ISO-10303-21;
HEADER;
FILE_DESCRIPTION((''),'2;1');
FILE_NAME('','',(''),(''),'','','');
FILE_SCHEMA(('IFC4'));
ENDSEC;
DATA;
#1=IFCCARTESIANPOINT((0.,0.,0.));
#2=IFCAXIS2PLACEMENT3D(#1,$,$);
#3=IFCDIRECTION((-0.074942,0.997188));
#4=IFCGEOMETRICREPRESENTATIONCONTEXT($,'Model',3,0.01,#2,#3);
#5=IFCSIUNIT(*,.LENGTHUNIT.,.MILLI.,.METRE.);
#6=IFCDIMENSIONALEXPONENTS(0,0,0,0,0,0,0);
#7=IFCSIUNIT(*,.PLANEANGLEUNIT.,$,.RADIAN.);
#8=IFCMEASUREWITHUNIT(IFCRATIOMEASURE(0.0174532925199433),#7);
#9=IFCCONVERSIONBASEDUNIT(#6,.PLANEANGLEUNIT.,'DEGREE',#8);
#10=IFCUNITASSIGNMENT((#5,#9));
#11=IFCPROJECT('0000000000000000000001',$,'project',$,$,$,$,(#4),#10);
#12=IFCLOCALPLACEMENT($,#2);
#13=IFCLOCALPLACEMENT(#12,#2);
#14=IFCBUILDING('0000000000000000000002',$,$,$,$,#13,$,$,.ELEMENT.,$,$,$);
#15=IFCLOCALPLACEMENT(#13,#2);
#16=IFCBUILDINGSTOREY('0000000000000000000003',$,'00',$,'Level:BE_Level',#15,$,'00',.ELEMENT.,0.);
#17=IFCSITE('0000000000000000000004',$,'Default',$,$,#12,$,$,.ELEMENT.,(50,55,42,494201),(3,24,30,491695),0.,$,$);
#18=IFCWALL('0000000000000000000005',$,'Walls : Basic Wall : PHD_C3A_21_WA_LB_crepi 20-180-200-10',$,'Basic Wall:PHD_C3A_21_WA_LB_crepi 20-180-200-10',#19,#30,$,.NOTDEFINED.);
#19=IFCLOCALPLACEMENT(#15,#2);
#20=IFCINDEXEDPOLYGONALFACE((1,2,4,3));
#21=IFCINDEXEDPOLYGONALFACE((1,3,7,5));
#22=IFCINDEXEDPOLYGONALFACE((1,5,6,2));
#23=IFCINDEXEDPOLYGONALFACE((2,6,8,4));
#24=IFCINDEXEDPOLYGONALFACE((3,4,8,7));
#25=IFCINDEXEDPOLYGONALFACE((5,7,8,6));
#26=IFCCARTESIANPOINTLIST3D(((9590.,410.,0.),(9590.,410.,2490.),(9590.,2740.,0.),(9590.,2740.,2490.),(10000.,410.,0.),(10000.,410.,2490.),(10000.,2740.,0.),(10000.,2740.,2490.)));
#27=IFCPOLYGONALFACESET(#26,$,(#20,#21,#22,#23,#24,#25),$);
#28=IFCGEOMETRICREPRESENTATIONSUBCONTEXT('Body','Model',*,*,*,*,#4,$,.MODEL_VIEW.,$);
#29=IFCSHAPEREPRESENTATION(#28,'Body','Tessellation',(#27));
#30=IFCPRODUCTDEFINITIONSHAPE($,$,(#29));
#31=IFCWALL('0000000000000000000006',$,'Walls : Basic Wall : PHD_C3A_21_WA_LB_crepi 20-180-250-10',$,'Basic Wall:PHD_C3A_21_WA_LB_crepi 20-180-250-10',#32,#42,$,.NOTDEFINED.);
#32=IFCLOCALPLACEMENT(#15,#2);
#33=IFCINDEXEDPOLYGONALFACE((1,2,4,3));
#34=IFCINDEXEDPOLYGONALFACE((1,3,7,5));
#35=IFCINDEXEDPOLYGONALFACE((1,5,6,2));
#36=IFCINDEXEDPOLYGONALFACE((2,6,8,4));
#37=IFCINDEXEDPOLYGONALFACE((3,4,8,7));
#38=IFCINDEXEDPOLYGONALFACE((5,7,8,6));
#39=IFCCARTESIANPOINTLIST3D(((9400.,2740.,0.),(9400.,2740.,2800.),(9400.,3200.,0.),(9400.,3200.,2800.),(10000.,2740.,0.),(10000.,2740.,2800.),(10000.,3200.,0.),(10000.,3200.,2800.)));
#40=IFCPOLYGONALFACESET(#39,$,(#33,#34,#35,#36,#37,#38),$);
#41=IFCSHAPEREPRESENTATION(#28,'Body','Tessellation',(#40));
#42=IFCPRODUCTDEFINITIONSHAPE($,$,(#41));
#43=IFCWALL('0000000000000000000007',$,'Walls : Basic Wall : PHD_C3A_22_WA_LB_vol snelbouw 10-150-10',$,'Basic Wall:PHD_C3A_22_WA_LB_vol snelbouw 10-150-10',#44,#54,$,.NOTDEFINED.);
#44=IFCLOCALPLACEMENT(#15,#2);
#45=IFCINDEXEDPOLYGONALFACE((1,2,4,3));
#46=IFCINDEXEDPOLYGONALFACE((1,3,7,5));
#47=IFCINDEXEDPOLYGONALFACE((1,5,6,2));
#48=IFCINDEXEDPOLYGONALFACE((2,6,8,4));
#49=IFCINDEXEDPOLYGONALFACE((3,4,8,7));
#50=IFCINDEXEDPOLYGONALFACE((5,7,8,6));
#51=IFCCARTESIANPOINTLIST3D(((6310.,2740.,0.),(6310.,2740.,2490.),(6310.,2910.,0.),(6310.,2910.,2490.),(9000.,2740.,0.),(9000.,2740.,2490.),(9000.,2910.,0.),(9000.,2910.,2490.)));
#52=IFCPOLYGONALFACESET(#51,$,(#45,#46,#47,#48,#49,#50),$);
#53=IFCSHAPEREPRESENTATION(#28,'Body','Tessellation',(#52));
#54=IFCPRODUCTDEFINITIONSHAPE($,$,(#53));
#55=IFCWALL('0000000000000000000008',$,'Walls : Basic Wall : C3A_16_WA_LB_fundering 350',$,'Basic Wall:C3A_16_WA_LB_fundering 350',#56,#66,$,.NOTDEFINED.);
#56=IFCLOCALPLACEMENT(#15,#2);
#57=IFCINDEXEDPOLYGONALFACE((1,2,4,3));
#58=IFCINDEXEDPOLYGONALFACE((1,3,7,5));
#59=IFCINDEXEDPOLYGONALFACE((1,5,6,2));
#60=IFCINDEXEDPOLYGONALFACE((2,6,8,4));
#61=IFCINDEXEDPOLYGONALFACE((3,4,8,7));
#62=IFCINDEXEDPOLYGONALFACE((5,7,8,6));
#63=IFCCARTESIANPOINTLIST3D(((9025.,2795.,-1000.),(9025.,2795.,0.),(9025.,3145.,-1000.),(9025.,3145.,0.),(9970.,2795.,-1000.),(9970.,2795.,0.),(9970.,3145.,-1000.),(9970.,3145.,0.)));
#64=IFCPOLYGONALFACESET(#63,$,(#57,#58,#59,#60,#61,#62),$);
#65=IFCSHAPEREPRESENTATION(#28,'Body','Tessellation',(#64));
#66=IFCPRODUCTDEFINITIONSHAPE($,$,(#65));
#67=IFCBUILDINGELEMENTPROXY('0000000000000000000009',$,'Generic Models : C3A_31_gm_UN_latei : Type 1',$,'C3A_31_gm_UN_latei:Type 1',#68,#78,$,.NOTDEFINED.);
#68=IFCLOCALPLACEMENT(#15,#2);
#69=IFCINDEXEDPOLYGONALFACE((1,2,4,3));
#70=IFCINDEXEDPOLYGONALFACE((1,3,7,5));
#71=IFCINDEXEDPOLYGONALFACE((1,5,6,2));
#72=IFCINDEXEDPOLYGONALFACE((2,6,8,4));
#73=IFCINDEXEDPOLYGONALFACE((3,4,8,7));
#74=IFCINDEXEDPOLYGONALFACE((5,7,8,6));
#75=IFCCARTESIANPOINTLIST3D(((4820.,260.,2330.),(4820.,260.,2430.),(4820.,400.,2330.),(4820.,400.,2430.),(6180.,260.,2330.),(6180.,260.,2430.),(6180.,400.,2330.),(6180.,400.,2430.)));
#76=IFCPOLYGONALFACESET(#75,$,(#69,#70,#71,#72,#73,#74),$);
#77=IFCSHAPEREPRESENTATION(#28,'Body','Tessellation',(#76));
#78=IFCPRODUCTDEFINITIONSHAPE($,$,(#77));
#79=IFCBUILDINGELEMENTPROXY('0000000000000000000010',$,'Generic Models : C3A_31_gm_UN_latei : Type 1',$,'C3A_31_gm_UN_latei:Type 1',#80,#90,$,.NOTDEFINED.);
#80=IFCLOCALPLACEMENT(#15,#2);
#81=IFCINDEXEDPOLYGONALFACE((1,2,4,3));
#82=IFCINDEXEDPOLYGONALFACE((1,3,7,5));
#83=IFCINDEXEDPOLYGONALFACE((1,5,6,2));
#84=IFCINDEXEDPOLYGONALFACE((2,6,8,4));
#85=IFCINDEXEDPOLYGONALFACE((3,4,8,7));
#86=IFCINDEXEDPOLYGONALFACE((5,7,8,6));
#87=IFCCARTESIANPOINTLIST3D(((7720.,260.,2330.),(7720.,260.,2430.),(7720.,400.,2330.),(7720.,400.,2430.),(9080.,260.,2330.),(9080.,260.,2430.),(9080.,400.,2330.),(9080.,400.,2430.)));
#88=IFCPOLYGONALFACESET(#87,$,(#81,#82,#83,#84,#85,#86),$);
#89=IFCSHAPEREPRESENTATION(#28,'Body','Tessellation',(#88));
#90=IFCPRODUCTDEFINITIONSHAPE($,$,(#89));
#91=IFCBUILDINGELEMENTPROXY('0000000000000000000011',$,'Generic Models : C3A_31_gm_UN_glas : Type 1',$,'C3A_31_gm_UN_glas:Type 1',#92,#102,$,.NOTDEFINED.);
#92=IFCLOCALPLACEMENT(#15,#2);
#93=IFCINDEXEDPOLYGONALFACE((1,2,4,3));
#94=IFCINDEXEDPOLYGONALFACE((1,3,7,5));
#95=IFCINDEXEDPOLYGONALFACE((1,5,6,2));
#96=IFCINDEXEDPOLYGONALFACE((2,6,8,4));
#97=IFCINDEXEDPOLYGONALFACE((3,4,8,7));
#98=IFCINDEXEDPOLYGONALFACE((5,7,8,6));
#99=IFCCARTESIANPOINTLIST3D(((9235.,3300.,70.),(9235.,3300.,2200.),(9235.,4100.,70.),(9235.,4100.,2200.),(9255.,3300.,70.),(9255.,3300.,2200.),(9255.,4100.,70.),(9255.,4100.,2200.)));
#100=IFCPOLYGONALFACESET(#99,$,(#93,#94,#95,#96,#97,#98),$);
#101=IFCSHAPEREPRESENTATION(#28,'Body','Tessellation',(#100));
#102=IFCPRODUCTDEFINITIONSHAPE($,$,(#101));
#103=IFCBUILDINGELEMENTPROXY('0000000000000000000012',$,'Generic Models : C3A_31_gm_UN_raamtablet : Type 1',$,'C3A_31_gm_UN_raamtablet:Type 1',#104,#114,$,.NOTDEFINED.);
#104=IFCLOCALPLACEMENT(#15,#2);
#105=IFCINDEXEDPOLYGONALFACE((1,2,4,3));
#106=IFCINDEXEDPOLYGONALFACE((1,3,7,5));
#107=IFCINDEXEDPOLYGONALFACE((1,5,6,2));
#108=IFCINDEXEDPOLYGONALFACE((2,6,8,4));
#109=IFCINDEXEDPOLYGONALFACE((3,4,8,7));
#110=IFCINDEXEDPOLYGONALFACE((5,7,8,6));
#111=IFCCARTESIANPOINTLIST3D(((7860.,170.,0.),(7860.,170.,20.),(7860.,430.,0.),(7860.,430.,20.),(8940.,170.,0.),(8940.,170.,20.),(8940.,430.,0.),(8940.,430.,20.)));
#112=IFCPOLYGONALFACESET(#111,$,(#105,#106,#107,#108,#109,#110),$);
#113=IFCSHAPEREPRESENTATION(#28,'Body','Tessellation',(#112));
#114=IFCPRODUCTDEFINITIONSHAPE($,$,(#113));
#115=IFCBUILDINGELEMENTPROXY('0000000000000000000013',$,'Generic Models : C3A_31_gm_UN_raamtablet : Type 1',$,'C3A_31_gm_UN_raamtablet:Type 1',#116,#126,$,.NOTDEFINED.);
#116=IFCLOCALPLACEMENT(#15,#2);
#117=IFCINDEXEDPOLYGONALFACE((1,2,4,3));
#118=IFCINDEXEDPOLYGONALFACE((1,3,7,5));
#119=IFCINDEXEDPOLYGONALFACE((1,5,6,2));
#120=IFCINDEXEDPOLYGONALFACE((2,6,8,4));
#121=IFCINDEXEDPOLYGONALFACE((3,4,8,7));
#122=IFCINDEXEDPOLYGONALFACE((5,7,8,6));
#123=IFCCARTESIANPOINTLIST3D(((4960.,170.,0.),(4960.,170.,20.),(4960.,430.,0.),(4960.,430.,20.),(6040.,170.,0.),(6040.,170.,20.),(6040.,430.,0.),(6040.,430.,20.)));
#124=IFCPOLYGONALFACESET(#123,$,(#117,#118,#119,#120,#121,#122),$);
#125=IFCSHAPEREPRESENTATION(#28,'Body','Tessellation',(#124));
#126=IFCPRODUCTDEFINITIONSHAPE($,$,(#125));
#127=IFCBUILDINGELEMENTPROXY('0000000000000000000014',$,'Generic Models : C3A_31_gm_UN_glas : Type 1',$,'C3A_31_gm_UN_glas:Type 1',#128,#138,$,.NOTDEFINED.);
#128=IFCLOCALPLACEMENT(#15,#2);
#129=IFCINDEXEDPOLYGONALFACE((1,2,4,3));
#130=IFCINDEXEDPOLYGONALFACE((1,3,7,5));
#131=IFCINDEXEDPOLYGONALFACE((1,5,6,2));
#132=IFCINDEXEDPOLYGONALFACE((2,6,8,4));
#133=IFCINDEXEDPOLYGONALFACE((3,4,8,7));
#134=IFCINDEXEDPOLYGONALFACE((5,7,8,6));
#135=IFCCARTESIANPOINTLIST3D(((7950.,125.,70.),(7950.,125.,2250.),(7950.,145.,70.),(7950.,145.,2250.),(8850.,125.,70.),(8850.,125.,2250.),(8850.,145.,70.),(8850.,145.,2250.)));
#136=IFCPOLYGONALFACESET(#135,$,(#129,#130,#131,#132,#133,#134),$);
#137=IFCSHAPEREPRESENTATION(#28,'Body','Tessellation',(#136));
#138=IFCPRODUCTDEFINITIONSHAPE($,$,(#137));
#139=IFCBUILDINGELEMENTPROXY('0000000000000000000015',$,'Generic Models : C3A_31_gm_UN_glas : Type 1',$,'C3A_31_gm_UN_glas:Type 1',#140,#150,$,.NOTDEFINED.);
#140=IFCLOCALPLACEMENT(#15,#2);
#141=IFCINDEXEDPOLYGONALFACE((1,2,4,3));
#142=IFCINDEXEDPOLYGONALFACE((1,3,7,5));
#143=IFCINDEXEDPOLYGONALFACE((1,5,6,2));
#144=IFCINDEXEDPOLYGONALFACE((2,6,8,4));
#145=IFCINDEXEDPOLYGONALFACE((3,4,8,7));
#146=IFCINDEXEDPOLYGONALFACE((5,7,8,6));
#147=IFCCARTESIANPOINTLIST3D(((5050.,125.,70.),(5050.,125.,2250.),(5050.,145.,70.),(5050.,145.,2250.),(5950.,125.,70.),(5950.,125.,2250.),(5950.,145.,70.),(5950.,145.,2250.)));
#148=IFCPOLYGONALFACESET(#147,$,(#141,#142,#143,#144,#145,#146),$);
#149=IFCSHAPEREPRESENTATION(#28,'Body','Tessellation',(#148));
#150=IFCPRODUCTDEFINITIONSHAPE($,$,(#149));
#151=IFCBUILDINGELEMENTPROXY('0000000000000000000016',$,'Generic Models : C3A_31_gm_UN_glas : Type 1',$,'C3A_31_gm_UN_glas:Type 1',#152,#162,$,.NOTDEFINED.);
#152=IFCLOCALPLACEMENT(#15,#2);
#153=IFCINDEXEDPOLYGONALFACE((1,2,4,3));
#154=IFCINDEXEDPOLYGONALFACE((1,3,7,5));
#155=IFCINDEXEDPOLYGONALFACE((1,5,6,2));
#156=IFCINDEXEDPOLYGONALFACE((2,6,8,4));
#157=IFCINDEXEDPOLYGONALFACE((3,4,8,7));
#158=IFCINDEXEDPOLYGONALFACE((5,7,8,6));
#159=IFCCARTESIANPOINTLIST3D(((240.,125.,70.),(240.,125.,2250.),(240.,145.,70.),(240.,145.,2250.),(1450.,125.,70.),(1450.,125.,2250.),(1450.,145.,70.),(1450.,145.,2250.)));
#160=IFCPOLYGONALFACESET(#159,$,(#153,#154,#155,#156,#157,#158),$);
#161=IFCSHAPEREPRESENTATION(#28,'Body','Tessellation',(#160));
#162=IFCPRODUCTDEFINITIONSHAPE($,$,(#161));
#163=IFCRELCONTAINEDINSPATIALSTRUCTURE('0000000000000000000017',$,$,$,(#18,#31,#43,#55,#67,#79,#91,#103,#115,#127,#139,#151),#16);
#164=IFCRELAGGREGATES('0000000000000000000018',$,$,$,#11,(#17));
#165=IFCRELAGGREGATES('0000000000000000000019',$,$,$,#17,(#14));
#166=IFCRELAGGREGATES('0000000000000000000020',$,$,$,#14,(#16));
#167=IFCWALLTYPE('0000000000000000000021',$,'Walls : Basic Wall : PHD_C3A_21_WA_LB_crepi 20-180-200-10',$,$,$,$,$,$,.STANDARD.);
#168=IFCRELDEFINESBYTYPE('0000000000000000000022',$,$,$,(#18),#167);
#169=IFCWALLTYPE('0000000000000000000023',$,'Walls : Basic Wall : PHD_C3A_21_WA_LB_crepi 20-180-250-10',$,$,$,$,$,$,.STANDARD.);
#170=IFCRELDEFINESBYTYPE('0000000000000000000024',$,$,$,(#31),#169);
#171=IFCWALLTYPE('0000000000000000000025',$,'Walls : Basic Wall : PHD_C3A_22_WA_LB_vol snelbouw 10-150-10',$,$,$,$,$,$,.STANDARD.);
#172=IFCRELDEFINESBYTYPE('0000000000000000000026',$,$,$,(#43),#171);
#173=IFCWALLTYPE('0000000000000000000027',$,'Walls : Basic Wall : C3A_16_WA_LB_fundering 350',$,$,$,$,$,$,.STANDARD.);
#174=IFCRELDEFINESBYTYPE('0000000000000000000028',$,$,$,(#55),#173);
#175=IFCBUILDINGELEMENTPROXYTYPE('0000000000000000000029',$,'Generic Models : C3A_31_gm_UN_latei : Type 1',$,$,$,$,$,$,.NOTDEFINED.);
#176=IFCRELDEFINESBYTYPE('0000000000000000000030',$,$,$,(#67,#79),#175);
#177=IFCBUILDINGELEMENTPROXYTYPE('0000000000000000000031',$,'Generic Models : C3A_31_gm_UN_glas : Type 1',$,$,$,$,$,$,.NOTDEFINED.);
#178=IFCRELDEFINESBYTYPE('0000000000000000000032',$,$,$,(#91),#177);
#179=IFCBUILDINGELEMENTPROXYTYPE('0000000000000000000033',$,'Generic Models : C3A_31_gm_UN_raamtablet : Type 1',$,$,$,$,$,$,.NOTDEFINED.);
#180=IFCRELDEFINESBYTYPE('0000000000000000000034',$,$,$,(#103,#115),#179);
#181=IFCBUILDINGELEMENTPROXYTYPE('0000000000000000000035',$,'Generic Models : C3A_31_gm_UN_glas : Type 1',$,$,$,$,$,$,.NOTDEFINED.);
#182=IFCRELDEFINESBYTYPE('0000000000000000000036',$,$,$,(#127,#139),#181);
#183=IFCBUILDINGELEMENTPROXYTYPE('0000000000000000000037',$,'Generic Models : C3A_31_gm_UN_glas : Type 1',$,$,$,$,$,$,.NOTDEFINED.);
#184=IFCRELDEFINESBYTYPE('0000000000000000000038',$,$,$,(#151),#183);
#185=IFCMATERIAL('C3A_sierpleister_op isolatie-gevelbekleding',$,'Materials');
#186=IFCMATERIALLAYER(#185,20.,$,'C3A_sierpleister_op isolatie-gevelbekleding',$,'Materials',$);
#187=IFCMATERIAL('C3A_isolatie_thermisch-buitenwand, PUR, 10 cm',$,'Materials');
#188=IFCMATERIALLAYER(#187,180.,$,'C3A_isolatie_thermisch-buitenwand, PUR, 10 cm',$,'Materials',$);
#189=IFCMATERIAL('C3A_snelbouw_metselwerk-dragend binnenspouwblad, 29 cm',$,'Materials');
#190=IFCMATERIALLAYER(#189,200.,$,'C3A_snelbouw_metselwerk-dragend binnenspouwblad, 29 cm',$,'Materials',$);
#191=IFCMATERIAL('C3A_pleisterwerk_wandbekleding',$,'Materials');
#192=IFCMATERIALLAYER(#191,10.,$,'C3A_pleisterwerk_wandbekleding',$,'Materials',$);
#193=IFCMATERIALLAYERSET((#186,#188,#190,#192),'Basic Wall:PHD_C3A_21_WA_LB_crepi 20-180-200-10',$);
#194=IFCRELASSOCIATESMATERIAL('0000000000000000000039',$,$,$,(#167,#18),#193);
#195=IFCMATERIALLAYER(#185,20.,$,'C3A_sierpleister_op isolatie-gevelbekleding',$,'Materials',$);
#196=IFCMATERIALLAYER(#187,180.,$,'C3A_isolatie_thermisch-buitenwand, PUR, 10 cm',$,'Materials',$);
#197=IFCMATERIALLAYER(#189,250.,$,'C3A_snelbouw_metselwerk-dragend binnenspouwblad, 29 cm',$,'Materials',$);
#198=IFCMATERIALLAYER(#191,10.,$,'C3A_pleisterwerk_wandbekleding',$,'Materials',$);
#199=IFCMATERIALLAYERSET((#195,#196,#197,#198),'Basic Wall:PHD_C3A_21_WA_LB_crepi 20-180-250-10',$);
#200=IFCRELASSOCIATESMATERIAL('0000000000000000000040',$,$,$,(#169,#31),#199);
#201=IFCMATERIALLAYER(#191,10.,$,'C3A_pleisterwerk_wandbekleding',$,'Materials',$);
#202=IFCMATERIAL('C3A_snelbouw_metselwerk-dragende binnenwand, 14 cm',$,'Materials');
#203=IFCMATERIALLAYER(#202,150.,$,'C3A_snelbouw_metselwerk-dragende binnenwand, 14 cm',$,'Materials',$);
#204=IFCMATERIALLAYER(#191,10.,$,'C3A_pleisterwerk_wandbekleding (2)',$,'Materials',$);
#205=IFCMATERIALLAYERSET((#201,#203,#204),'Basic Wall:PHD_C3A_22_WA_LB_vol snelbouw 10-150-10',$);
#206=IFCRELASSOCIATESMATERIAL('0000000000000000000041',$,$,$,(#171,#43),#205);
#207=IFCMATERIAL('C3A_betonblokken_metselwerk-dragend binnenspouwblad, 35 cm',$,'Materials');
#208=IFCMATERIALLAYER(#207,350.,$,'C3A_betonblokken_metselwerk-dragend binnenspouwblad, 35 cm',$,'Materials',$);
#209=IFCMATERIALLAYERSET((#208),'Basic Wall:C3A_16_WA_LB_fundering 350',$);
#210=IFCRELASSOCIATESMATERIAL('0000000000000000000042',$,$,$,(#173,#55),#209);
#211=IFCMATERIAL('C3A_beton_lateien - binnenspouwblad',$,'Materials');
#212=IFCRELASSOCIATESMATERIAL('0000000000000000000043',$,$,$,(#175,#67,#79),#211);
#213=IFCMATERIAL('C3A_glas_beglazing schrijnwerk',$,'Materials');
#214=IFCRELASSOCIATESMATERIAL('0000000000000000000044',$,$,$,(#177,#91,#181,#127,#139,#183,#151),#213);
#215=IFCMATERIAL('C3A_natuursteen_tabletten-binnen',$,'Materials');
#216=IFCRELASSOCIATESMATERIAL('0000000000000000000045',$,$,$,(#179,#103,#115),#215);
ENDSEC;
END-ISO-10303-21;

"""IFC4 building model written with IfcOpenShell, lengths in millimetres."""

from ifc_helpers import new_model, entity, si_unit, converted_unit, direction, frame, frame_2d, origin, origin_2d_with_axis, place, context, subcontext, project, spatial, polyline, rectangle, extrude, clip, bounded_halfspace, source, transform, mapped, material, layer, layer_set, layer_usage, type_object, type_shapes, element, save


model = new_model("IFC4")

# Units and contexts
model_context = context("Model", 3, precision=0.01, world=origin(), true_north=direction((-0.074942, 0.997188)))
body_context = subcontext(model_context, "Body", "Model", "MODEL_VIEW")
ifc_project = project(units=[si_unit("LENGTHUNIT", "METRE", prefix="MILLI"), converted_unit("PLANEANGLEUNIT", "DEGREE", entity("IfcRatioMeasure", 0.0174532925199433), si_unit("PLANEANGLEUNIT", "RADIAN"), dimensions=[0, 0, 0, 0, 0, 0, 0])], contexts=[model_context])

# Site, building, storey
site_placement = place(None, origin())
site = spatial("IfcSite", under=ifc_project, at=site_placement, Name="Default", CompositionType="ELEMENT", RefLatitude=(50, 55, 42, 494201), RefLongitude=(3, 24, 30, 491695), RefElevation=0.0)
building_placement = place(site_placement, origin())
building = spatial("IfcBuilding", under=site, at=building_placement, CompositionType="ELEMENT")
storey_placement = place(building_placement, frame((0.0, 0.0, 0.0)))
storey = spatial("IfcBuildingStorey", under=building, at=storey_placement, Name="00", ObjectType="Level:BE_Level", LongName="00", CompositionType="ELEMENT", Elevation=0.0)

# Walls
ifc_material_1 = material(Name="C3A_sierpleister_op isolatie-gevelbekleding", Category="Materials")
ifc_layer_1 = layer(ifc_material_1, 20.0, Name="C3A_sierpleister_op isolatie-gevelbekleding", Category="Materials")
ifc_material_2 = material(Name="C3A_isolatie_thermisch-buitenwand, PUR, 10 cm", Category="Materials")
ifc_layer_2 = layer(ifc_material_2, 180.0, Name="C3A_isolatie_thermisch-buitenwand, PUR, 10 cm", Category="Materials")
ifc_material_3 = material(Name="C3A_snelbouw_metselwerk-dragend binnenspouwblad, 29 cm", Category="Materials")
ifc_layer_3 = layer(ifc_material_3, 200.0, Name="C3A_snelbouw_metselwerk-dragend binnenspouwblad, 29 cm", Category="Materials")
ifc_material_4 = material(Name="C3A_pleisterwerk_wandbekleding", Category="Materials")
ifc_layer_4 = layer(ifc_material_4, 10.0, Name="C3A_pleisterwerk_wandbekleding", Category="Materials")
ifc_layer_set_1 = layer_set([ifc_layer_1, ifc_layer_2, ifc_layer_3, ifc_layer_4], Name="Basic Wall:PHD_C3A_21_WA_LB_crepi 20-180-200-10")
ifc_layer_usage_1 = layer_usage(ifc_layer_set_1, "AXIS2", "POSITIVE", -205.0)
wall_type_1 = type_object("IfcWallType", Name="Walls : Basic Wall : PHD_C3A_21_WA_LB_crepi 20-180-200-10", PredefinedType="STANDARD", material=ifc_layer_set_1)
wall_1_placement = place(storey_placement, frame((9795.0, 410.0, 0.0), z_axis=(0.0, 0.0, 1.0), x_axis=(0.0, 1.0, 0.0)))
element("IfcWall", 1, at=wall_1_placement, inside=storey, type_object=wall_type_1, material=ifc_layer_usage_1, Name="Walls : Basic Wall : PHD_C3A_21_WA_LB_crepi 20-180-200-10", ObjectType="Basic Wall:PHD_C3A_21_WA_LB_crepi 20-180-200-10", PredefinedType="NOTDEFINED", context=body_context, shape_type="Clipping", body=[
    clip(extrude(rectangle(XDim=2330.0, YDim=410.0, at=frame_2d((1165.0, 0.0), x_axis=(-1.0, 0.0))), origin(), (0.0, 0.0, 1.0), 2490.0), bounded_halfspace(frame((2330.0, 205.0, 2490.0), z_axis=(0.0, 0.0, -1.0), x_axis=(-1.0, 0.0, 0.0)), True, frame((2330.0, 205.0, 2490.0), z_axis=(0.0, 0.0, -1.0), x_axis=(-1.0, 0.0, 0.0)), polyline([(0.0, 0.0), (0.0, -210.0), (0.0, -410.0), (2330.0, -410.0), (2330.0, -210.0), (2330.0, 0.0), (0.0, 0.0)]))),
])
ifc_layer_5 = layer(ifc_material_1, 20.0, Name="C3A_sierpleister_op isolatie-gevelbekleding", Category="Materials")
ifc_layer_6 = layer(ifc_material_2, 180.0, Name="C3A_isolatie_thermisch-buitenwand, PUR, 10 cm", Category="Materials")
ifc_layer_7 = layer(ifc_material_3, 250.0, Name="C3A_snelbouw_metselwerk-dragend binnenspouwblad, 29 cm", Category="Materials")
ifc_layer_8 = layer(ifc_material_4, 10.0, Name="C3A_pleisterwerk_wandbekleding", Category="Materials")
ifc_layer_set_2 = layer_set([ifc_layer_5, ifc_layer_6, ifc_layer_7, ifc_layer_8], Name="Basic Wall:PHD_C3A_21_WA_LB_crepi 20-180-250-10")
ifc_layer_usage_2 = layer_usage(ifc_layer_set_2, "AXIS2", "POSITIVE", -230.0)
wall_type_2 = type_object("IfcWallType", Name="Walls : Basic Wall : PHD_C3A_21_WA_LB_crepi 20-180-250-10", PredefinedType="STANDARD", material=ifc_layer_set_2)
wall_2_placement = place(storey_placement, frame((10000.0, 2970.0, 0.0), z_axis=(0.0, 0.0, 1.0), x_axis=(-1.0, 0.0, 0.0)))
element("IfcWall", 2, at=wall_2_placement, inside=storey, type_object=wall_type_2, material=ifc_layer_usage_2, Name="Walls : Basic Wall : PHD_C3A_21_WA_LB_crepi 20-180-250-10", ObjectType="Basic Wall:PHD_C3A_21_WA_LB_crepi 20-180-250-10", PredefinedType="NOTDEFINED", context=body_context, shape_type="SweptSolid", body=[
    extrude(rectangle(XDim=600.0, YDim=460.0, at=frame_2d((300.0, 0.0), x_axis=(-1.0, 0.0))), origin(), (0.0, 0.0, 1.0), 2800.0),
])
ifc_layer_9 = layer(ifc_material_4, 10.0, Name="C3A_pleisterwerk_wandbekleding", Category="Materials")
ifc_material_5 = material(Name="C3A_snelbouw_metselwerk-dragende binnenwand, 14 cm", Category="Materials")
ifc_layer_10 = layer(ifc_material_5, 150.0, Name="C3A_snelbouw_metselwerk-dragende binnenwand, 14 cm", Category="Materials")
ifc_layer_11 = layer(ifc_material_4, 10.0, Name="C3A_pleisterwerk_wandbekleding (2)", Category="Materials")
ifc_layer_set_3 = layer_set([ifc_layer_9, ifc_layer_10, ifc_layer_11], Name="Basic Wall:PHD_C3A_22_WA_LB_vol snelbouw 10-150-10")
ifc_layer_usage_3 = layer_usage(ifc_layer_set_3, "AXIS2", "NEGATIVE", 85.0)
wall_type_3 = type_object("IfcWallType", Name="Walls : Basic Wall : PHD_C3A_22_WA_LB_vol snelbouw 10-150-10", PredefinedType="STANDARD", material=ifc_layer_set_3)
wall_3_placement = place(storey_placement, frame((6310.0, 2825.0, 0.0)))
element("IfcWall", 3, at=wall_3_placement, inside=storey, type_object=wall_type_3, material=ifc_layer_usage_3, Name="Walls : Basic Wall : PHD_C3A_22_WA_LB_vol snelbouw 10-150-10", ObjectType="Basic Wall:PHD_C3A_22_WA_LB_vol snelbouw 10-150-10", PredefinedType="NOTDEFINED", context=body_context, shape_type="Clipping", body=[
    clip(extrude(rectangle(XDim=2690.0, YDim=170.0, at=frame_2d((1345.0, 0.0), x_axis=(-1.0, 0.0))), origin(), (0.0, 0.0, 1.0), 2490.0), bounded_halfspace(frame((0.0, -85.0, 2490.0), z_axis=(0.0, 0.0, -1.0), x_axis=(0.0, -1.0, 0.0)), True, frame((0.0, -85.0, 2490.0), z_axis=(0.0, 0.0, -1.0), x_axis=(0.0, -1.0, 0.0)), polyline([(0.0, 0.0), (-170.0, 0.0), (-170.0, -2690.0), (0.0, -2690.0), (0.0, 0.0)]))),
])

# Wall
ifc_material_6 = material(Name="C3A_betonblokken_metselwerk-dragend binnenspouwblad, 35 cm", Category="Materials")
ifc_layer_12 = layer(ifc_material_6, 350.0, Name="C3A_betonblokken_metselwerk-dragend binnenspouwblad, 35 cm", Category="Materials")
ifc_layer_set_4 = layer_set([ifc_layer_12], Name="Basic Wall:C3A_16_WA_LB_fundering 350")
ifc_layer_usage_4 = layer_usage(ifc_layer_set_4, "AXIS2", "NEGATIVE", 175.0)
wall_type_4 = type_object("IfcWallType", Name="Walls : Basic Wall : C3A_16_WA_LB_fundering 350", PredefinedType="STANDARD", material=ifc_layer_set_4)
wall_4_placement = place(storey_placement, frame((9025.0, 2970.0, -1000.0)))
element("IfcWall", 4, at=wall_4_placement, inside=storey, type_object=wall_type_4, material=ifc_layer_usage_4, Name="Walls : Basic Wall : C3A_16_WA_LB_fundering 350", ObjectType="Basic Wall:C3A_16_WA_LB_fundering 350", PredefinedType="NOTDEFINED", context=body_context, shape_type="SweptSolid", body=[
    extrude(rectangle(XDim=945.0, YDim=350.0, at=frame_2d((472.5, 0.0), x_axis=(-1.0, 0.0))), origin(), (0.0, 0.0, 1.0), 1000.0),
])

# Building element proxies
ifc_material_7 = material(Name="C3A_beton_lateien - binnenspouwblad", Category="Materials")
building_element_proxy_type_1 = type_object("IfcBuildingElementProxyType", Name="Generic Models : C3A_31_gm_UN_latei : Type 1", PredefinedType="NOTDEFINED", material=ifc_material_7)
shared_shape_1 = source(origin(), body_context, "Body", "SweptSolid", [
    extrude(rectangle(XDim=1360.0, YDim=140.0, at=origin_2d_with_axis()), frame((0.0, 70.0, 0.0), z_axis=(0.0, 0.0, 1.0), x_axis=(-1.0, 0.0, 0.0)), (0.0, 0.0, 1.0), 100.0),
])
type_shapes(building_element_proxy_type_1, [shared_shape_1])
for number, where, z_axis, x_axis, name in (
    (5, (5500.0, 400.0, 2330.0), (0.0, 0.0, 1.0), (-1.0, 0.0, 0.0), "Generic Models : C3A_31_gm_UN_latei : Type 1"),
    (6, (8400.0, 400.0, 2330.0), (0.0, 0.0, 1.0), (-1.0, 0.0, 0.0), "Generic Models : C3A_31_gm_UN_latei : Type 1"),
):
    element("IfcBuildingElementProxy", number, at=place(storey_placement, frame(where, z_axis=z_axis, x_axis=x_axis)), inside=storey, type_object=building_element_proxy_type_1, material=ifc_material_7, Name=name, ObjectType="C3A_31_gm_UN_latei:Type 1", PredefinedType="NOTDEFINED", context=body_context, shape_type="MappedRepresentation", body=[
        mapped(shared_shape_1, transform((0.0, 0.0, 0.0), scale=1.0)),
    ])
ifc_material_8 = material(Name="C3A_glas_beglazing schrijnwerk", Category="Materials")
building_element_proxy_type_2 = type_object("IfcBuildingElementProxyType", Name="Generic Models : C3A_31_gm_UN_glas : Type 1", PredefinedType="NOTDEFINED", material=ifc_material_8)
shared_shape_2 = source(origin(), body_context, "Body", "SweptSolid", [
    extrude(rectangle(XDim=800.0, YDim=20.0, at=origin_2d_with_axis()), frame((400.0, 10.0, 0.0), z_axis=(0.0, 0.0, 1.0), x_axis=(-1.0, 0.0, 0.0)), (0.0, 0.0, 1.0), 2130.0),
])
type_shapes(building_element_proxy_type_2, [shared_shape_2])
proxy_1_placement = place(storey_placement, frame((9235.0, 4100.0, 70.0), z_axis=(0.0, 0.0, 1.0), x_axis=(0.0, -1.0, 0.0)))
element("IfcBuildingElementProxy", 7, at=proxy_1_placement, inside=storey, type_object=building_element_proxy_type_2, material=ifc_material_8, Name="Generic Models : C3A_31_gm_UN_glas : Type 1", ObjectType="C3A_31_gm_UN_glas:Type 1", PredefinedType="NOTDEFINED", context=body_context, shape_type="MappedRepresentation", body=[
    mapped(shared_shape_2, transform((0.0, 0.0, 0.0), scale=1.0)),
])
ifc_material_9 = material(Name="C3A_natuursteen_tabletten-binnen", Category="Materials")
building_element_proxy_type_3 = type_object("IfcBuildingElementProxyType", Name="Generic Models : C3A_31_gm_UN_raamtablet : Type 1", PredefinedType="NOTDEFINED", material=ifc_material_9)
shared_shape_3 = source(origin(), body_context, "Body", "SweptSolid", [
    extrude(rectangle(XDim=1080.0, YDim=260.0, at=origin_2d_with_axis()), frame((0.0, 130.0, 0.0), z_axis=(0.0, 0.0, 1.0), x_axis=(-1.0, 0.0, 0.0)), (0.0, 0.0, 1.0), 20.0),
])
type_shapes(building_element_proxy_type_3, [shared_shape_3])
for number, where, z_axis, x_axis, name in (
    (8, (8400.0, 430.0, 0.0), (0.0, 0.0, 1.0), (-1.0, 0.0, 0.0), "Generic Models : C3A_31_gm_UN_raamtablet : Type 1"),
    (9, (5500.0, 430.0, 0.0), (0.0, 0.0, 1.0), (-1.0, 0.0, 0.0), "Generic Models : C3A_31_gm_UN_raamtablet : Type 1"),
):
    element("IfcBuildingElementProxy", number, at=place(storey_placement, frame(where, z_axis=z_axis, x_axis=x_axis)), inside=storey, type_object=building_element_proxy_type_3, material=ifc_material_9, Name=name, ObjectType="C3A_31_gm_UN_raamtablet:Type 1", PredefinedType="NOTDEFINED", context=body_context, shape_type="MappedRepresentation", body=[
        mapped(shared_shape_3, transform((0.0, 0.0, 0.0), scale=1.0)),
    ])
building_element_proxy_type_4 = type_object("IfcBuildingElementProxyType", Name="Generic Models : C3A_31_gm_UN_glas : Type 1", PredefinedType="NOTDEFINED", material=ifc_material_8)
shared_shape_4 = source(origin(), body_context, "Body", "SweptSolid", [
    extrude(rectangle(XDim=900.0, YDim=20.0, at=origin_2d_with_axis()), frame((450.0, 10.0, 0.0), z_axis=(0.0, 0.0, 1.0), x_axis=(-1.0, 0.0, 0.0)), (0.0, 0.0, 1.0), 2180.0),
])
type_shapes(building_element_proxy_type_4, [shared_shape_4])
for number, where, z_axis, x_axis, name in (
    (10, (8850.0, 145.0, 70.0), (0.0, 0.0, 1.0), (-1.0, 0.0, 0.0), "Generic Models : C3A_31_gm_UN_glas : Type 1"),
    (11, (5950.0, 145.0, 70.0), (0.0, 0.0, 1.0), (-1.0, 0.0, 0.0), "Generic Models : C3A_31_gm_UN_glas : Type 1"),
):
    element("IfcBuildingElementProxy", number, at=place(storey_placement, frame(where, z_axis=z_axis, x_axis=x_axis)), inside=storey, type_object=building_element_proxy_type_4, material=ifc_material_8, Name=name, ObjectType="C3A_31_gm_UN_glas:Type 1", PredefinedType="NOTDEFINED", context=body_context, shape_type="MappedRepresentation", body=[
        mapped(shared_shape_4, transform((0.0, 0.0, 0.0), scale=1.0)),
    ])
building_element_proxy_type_5 = type_object("IfcBuildingElementProxyType", Name="Generic Models : C3A_31_gm_UN_glas : Type 1", PredefinedType="NOTDEFINED", material=ifc_material_8)
shared_shape_5 = source(origin(), body_context, "Body", "SweptSolid", [
    extrude(rectangle(XDim=20.0, YDim=1210.0, at=origin_2d_with_axis()), frame((605.0, 10.0, 0.0), z_axis=(0.0, 0.0, 1.0), x_axis=(0.0, 1.0, 0.0)), (0.0, 0.0, 1.0), 2180.0),
])
type_shapes(building_element_proxy_type_5, [shared_shape_5])
proxy_2_placement = place(storey_placement, frame((240.0, 125.0, 70.0)))
element("IfcBuildingElementProxy", 12, at=proxy_2_placement, inside=storey, type_object=building_element_proxy_type_5, material=ifc_material_8, Name="Generic Models : C3A_31_gm_UN_glas : Type 1", ObjectType="C3A_31_gm_UN_glas:Type 1", PredefinedType="NOTDEFINED", context=body_context, shape_type="MappedRepresentation", body=[
    mapped(shared_shape_5, transform((0.0, 0.0, 0.0), scale=1.0)),
])

save(model, "model.ifc")
